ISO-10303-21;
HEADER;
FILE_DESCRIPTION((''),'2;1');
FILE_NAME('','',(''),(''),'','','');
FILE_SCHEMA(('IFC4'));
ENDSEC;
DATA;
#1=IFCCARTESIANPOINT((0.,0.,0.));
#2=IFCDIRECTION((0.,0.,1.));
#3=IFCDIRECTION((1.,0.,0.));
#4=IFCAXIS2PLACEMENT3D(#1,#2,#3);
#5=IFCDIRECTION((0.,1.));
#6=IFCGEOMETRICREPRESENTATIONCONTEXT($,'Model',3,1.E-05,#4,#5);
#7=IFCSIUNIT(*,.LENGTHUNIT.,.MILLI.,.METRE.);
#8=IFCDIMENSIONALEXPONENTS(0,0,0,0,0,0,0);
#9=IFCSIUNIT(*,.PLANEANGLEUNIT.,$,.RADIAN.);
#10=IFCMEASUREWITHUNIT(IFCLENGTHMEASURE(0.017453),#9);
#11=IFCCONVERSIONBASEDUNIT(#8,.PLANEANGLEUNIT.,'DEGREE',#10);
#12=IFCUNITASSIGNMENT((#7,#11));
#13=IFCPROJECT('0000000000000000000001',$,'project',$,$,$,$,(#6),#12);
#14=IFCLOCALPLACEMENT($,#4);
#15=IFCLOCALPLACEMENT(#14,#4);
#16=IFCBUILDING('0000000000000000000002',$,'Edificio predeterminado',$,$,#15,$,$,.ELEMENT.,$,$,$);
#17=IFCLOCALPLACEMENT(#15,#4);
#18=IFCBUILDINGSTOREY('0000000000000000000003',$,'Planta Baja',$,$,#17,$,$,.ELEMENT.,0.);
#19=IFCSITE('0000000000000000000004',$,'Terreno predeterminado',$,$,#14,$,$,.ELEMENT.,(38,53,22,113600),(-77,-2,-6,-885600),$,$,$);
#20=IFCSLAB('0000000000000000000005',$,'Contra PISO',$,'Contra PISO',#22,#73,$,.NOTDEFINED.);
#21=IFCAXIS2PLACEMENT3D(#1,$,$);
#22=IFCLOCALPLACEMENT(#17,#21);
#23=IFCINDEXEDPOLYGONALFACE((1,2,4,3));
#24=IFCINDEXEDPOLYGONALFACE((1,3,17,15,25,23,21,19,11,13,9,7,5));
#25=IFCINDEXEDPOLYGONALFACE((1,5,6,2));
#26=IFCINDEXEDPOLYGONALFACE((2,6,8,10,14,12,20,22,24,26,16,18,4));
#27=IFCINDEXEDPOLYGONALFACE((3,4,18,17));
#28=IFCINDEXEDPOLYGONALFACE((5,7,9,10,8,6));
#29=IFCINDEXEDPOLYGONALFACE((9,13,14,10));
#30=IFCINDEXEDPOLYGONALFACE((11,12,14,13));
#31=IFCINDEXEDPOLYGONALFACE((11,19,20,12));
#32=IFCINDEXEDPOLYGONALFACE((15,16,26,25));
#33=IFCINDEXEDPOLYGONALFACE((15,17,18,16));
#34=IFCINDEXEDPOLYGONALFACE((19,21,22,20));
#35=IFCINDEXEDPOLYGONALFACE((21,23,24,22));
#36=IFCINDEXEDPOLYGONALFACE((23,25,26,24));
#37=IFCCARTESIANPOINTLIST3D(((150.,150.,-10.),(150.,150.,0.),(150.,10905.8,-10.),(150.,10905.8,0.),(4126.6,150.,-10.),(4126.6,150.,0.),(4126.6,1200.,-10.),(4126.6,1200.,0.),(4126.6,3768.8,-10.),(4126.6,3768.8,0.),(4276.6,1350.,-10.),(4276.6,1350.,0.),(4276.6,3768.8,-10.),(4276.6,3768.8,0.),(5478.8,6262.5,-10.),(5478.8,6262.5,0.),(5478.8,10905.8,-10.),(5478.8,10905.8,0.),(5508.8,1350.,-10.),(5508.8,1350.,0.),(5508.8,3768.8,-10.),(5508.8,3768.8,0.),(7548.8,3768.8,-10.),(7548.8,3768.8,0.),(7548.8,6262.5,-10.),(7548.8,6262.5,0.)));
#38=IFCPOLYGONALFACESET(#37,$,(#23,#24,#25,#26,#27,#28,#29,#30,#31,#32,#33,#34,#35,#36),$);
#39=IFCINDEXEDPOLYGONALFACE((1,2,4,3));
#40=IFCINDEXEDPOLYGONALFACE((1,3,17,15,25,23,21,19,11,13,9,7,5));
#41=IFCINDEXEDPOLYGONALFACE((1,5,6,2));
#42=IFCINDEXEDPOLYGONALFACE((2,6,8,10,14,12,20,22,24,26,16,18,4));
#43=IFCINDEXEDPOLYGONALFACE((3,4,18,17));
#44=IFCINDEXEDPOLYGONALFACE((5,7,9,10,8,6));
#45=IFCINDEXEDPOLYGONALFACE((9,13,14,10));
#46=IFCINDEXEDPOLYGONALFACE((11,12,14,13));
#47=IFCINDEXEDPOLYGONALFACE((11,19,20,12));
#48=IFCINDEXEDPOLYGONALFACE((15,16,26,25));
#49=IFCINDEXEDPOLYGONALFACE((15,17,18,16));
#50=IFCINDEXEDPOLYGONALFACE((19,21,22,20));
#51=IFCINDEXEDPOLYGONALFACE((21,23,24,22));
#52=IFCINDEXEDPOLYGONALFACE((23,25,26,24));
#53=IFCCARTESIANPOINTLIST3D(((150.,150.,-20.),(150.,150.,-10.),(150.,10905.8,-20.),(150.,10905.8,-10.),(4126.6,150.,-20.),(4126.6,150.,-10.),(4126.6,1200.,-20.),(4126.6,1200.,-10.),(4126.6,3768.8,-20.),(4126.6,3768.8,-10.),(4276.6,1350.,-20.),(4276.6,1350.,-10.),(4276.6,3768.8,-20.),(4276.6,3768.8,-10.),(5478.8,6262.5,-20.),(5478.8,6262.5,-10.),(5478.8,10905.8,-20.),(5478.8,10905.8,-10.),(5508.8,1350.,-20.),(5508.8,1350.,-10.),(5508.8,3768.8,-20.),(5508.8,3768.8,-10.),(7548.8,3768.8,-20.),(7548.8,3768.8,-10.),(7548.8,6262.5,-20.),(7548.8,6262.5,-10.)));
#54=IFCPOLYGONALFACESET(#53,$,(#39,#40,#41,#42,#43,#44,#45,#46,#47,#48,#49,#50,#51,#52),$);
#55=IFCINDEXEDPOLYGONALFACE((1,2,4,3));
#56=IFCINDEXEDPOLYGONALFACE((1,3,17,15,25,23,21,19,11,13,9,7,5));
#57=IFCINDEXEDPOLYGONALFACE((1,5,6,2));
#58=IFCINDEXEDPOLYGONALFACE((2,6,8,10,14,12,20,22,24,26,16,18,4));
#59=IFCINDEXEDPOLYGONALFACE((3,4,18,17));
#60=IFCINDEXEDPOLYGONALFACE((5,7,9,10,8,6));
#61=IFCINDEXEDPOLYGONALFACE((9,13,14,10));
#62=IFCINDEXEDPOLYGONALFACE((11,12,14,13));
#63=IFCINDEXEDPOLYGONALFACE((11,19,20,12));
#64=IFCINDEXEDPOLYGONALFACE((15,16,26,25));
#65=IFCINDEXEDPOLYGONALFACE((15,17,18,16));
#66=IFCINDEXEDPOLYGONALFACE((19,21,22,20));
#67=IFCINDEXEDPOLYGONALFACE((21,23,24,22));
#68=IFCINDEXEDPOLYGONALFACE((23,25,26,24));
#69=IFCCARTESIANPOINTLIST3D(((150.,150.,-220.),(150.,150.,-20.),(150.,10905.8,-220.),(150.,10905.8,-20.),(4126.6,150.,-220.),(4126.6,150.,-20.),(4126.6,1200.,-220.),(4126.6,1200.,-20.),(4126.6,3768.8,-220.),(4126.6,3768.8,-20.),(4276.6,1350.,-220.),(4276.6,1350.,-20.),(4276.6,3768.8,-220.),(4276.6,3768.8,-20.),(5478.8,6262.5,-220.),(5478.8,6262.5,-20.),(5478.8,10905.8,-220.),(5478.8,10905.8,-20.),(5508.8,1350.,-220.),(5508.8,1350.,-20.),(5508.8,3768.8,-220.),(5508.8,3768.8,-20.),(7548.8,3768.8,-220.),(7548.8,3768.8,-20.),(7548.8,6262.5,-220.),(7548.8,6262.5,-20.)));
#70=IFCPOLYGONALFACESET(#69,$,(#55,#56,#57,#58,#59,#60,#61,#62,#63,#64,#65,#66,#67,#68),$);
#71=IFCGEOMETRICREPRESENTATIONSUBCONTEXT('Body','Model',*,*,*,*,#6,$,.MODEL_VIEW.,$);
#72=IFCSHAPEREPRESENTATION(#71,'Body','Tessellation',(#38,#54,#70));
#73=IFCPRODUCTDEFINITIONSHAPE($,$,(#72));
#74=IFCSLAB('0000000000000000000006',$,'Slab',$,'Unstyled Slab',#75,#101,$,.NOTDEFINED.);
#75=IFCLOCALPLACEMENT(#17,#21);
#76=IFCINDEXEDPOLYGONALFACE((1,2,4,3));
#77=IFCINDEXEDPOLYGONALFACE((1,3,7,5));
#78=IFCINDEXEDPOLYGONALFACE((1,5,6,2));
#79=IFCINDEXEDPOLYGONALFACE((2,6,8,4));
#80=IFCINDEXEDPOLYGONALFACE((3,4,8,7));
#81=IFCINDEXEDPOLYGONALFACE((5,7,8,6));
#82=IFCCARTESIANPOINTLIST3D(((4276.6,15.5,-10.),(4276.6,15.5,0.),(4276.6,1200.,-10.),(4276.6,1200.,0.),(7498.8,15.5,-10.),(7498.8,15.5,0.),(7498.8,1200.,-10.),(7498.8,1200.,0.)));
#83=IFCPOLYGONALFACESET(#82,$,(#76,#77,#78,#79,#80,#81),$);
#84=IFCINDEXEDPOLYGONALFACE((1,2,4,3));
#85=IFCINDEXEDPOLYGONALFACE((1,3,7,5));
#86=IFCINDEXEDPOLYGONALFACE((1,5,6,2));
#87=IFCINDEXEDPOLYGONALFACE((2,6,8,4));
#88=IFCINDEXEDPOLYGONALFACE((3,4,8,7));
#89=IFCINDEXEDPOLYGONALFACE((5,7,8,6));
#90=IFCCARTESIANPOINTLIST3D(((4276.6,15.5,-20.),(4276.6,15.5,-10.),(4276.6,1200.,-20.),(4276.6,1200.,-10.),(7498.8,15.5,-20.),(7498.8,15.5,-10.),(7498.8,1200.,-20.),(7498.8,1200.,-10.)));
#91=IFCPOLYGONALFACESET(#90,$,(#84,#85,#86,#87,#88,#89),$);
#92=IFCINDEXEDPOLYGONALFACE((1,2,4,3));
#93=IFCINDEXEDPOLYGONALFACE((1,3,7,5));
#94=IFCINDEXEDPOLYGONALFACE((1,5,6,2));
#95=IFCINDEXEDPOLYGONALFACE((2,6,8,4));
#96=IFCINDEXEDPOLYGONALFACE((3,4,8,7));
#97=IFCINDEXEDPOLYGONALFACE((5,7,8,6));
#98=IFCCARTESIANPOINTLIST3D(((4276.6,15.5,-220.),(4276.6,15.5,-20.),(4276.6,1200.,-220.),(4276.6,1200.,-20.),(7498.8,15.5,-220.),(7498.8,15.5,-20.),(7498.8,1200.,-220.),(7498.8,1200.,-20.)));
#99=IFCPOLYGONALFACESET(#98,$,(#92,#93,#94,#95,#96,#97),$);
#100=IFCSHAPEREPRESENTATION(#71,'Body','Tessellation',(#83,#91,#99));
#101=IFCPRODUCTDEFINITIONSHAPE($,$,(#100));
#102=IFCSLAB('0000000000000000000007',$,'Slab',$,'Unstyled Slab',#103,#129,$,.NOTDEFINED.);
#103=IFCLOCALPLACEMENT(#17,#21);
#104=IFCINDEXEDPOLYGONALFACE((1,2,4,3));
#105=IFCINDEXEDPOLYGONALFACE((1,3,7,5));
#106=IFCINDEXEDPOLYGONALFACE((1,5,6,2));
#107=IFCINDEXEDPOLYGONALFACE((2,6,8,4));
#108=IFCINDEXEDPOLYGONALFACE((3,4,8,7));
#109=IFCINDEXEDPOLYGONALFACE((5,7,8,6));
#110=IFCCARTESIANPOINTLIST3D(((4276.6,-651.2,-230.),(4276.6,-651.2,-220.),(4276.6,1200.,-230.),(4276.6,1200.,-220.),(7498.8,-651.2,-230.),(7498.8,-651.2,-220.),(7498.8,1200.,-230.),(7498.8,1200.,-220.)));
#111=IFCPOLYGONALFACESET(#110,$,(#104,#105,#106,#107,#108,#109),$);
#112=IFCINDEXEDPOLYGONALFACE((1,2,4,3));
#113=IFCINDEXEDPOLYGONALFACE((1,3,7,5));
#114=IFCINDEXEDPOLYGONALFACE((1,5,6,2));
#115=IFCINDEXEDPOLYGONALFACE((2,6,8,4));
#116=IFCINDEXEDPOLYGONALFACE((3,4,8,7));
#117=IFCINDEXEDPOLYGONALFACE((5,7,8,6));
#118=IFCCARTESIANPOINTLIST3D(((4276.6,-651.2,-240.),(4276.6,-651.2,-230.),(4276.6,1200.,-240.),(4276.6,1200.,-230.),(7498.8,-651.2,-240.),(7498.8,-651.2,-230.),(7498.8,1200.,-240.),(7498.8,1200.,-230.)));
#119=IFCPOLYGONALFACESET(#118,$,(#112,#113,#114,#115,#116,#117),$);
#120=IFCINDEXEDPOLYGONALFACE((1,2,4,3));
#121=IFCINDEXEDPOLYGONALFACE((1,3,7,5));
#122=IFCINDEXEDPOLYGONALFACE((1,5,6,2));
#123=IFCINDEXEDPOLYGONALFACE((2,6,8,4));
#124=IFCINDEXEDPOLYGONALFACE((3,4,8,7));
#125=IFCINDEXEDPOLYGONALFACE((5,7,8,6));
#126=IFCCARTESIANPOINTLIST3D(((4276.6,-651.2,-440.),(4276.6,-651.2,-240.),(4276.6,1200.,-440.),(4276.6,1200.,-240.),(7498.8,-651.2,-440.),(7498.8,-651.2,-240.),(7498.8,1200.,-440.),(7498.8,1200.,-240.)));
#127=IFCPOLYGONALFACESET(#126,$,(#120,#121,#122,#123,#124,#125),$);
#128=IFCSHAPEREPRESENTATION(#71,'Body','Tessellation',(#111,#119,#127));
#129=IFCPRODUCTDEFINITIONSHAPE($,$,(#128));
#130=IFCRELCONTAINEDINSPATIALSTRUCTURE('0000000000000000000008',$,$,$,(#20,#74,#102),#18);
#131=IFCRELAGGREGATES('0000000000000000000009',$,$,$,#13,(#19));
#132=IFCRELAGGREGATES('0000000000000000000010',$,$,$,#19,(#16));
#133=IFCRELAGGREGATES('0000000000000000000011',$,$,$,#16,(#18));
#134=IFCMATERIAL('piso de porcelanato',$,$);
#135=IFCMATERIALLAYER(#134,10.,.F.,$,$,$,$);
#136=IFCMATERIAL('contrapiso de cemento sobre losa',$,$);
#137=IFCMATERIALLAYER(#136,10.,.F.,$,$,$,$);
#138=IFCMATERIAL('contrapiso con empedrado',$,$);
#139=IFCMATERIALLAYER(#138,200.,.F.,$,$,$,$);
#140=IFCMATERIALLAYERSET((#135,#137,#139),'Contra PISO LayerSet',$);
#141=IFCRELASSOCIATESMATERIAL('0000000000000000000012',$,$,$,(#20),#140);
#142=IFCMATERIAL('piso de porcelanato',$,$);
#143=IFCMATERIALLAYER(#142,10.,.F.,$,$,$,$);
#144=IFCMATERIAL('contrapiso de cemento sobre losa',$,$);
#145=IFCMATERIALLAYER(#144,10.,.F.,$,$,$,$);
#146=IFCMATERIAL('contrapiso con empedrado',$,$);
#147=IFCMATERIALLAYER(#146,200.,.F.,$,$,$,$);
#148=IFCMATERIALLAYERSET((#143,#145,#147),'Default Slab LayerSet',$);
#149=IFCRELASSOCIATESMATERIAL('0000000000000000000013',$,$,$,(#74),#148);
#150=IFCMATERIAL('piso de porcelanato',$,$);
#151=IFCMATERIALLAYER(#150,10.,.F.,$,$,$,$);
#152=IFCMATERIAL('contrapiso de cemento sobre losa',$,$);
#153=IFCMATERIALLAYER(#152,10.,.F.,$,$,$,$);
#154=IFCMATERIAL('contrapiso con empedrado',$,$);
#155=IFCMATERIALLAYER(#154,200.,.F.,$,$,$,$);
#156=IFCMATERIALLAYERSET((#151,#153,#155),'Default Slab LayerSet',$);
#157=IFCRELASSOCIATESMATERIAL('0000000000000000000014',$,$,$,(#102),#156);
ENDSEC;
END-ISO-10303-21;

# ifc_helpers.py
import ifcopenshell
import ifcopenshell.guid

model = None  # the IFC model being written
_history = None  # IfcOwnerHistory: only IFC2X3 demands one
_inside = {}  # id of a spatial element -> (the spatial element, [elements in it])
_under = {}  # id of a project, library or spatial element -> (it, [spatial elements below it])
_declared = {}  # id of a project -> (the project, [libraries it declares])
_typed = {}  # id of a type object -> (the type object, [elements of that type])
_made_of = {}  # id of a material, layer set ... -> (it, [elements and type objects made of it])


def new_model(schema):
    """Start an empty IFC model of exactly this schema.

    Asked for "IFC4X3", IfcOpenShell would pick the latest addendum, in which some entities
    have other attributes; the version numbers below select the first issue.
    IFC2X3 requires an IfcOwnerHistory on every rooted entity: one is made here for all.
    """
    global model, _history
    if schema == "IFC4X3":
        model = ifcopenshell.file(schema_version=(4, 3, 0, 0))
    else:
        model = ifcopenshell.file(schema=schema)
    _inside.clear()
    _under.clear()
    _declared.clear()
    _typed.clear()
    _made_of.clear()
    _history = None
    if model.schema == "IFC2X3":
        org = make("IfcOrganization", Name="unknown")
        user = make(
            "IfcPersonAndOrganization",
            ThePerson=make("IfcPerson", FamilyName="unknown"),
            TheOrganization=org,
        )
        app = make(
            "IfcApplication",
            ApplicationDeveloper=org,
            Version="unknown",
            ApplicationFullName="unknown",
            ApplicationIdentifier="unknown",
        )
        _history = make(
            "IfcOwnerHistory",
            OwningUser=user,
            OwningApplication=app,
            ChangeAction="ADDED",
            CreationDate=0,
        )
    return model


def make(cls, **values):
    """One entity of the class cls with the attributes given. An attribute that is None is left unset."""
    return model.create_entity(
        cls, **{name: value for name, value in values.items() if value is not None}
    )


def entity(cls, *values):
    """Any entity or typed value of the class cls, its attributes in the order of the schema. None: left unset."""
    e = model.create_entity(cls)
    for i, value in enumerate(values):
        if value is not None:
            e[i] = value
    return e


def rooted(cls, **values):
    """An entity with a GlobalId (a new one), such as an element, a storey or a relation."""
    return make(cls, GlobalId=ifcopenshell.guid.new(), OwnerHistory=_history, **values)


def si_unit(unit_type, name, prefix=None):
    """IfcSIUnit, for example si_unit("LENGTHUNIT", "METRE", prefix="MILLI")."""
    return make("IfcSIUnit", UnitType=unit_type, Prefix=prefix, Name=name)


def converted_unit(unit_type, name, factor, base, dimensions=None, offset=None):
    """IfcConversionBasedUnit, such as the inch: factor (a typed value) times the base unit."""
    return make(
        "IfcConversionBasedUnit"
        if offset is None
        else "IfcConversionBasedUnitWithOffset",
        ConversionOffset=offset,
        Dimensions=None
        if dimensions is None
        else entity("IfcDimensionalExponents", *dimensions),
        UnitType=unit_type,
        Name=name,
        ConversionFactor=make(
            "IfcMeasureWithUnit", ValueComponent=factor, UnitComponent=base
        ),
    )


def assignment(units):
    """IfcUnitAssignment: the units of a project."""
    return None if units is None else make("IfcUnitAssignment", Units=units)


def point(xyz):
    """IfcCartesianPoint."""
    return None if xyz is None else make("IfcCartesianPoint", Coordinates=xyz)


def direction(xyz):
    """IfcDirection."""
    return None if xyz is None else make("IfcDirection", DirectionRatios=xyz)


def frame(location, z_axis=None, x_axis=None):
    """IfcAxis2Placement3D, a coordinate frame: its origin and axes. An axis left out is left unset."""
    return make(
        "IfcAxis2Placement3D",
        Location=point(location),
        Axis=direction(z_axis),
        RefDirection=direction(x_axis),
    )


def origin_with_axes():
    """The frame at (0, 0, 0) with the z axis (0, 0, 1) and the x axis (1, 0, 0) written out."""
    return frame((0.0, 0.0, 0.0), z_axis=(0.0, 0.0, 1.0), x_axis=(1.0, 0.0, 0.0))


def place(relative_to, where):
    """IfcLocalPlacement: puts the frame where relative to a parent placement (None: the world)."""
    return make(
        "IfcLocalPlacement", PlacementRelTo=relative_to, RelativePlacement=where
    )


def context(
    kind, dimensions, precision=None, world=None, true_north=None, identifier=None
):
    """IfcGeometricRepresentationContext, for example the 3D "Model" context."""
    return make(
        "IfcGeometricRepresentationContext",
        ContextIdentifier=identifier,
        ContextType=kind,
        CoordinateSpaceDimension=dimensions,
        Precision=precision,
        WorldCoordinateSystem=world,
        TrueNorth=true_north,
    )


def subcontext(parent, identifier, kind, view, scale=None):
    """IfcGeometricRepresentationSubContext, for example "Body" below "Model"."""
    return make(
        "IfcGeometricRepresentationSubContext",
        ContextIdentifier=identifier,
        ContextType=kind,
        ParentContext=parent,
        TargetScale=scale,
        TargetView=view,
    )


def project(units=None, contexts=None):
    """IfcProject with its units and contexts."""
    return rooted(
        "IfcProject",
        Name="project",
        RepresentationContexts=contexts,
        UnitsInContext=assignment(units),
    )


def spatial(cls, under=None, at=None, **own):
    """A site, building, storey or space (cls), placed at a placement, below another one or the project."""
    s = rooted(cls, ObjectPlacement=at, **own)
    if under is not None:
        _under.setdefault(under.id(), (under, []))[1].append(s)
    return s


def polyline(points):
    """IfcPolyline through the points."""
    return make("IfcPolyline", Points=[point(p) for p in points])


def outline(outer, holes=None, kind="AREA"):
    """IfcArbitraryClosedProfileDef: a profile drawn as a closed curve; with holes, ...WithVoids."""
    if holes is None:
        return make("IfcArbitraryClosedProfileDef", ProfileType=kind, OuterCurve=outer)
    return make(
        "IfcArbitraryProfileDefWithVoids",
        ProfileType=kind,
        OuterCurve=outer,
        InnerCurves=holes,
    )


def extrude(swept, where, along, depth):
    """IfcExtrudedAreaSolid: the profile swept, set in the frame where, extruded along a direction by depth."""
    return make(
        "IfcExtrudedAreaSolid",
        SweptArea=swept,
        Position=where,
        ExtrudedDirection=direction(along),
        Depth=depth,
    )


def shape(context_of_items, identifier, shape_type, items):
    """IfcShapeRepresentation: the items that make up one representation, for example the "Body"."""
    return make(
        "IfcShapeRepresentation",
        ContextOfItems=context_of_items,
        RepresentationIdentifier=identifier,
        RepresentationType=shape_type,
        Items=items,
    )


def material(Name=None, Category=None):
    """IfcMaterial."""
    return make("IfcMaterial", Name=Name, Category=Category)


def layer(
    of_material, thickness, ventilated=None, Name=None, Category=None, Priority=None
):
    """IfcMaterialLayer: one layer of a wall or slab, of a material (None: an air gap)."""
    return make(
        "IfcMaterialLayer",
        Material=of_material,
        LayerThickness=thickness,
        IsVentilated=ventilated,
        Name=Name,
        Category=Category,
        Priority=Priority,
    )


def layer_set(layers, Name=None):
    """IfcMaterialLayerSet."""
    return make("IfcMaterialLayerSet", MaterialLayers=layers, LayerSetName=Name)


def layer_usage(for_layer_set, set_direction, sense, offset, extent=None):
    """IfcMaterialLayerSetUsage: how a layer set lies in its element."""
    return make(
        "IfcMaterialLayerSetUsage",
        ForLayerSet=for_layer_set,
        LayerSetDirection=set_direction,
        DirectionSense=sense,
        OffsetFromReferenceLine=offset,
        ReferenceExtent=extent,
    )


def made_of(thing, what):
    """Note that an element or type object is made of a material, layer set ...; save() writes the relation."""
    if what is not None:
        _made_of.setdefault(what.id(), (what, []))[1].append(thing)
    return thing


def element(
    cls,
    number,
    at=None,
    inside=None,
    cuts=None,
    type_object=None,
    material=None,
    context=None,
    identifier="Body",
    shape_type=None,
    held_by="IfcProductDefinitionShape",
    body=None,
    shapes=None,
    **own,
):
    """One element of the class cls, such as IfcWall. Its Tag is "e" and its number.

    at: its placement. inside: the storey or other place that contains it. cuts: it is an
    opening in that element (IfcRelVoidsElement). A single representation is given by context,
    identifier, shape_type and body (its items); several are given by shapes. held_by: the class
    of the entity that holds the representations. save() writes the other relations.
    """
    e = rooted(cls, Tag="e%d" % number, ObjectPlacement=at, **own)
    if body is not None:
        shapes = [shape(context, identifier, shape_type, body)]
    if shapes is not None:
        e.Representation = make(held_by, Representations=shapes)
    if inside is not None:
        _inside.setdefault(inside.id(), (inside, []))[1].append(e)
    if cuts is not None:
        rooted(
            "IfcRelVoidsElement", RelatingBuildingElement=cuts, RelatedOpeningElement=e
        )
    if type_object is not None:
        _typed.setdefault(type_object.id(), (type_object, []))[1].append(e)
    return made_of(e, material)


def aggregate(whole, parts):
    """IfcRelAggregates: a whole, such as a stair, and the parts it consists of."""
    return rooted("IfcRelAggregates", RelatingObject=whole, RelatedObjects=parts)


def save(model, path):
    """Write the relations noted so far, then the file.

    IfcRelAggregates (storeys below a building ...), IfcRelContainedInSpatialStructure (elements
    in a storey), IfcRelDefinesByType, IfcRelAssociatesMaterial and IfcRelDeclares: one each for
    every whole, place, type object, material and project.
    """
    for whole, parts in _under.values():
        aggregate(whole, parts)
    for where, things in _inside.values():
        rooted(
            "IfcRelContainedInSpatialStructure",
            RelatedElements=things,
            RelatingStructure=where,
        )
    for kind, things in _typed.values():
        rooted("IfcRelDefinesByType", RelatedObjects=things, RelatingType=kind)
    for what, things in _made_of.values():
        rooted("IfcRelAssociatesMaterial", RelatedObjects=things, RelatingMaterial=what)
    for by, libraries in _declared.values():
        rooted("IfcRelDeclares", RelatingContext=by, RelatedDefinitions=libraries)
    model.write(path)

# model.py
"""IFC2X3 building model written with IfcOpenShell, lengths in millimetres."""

from ifc_helpers import new_model, entity, si_unit, converted_unit, direction, frame, origin_with_axes, place, context, subcontext, project, spatial, polyline, outline, extrude, material, layer, layer_set, layer_usage, element, save


model = new_model("IFC2X3")

# Units and contexts
model_context = context("Model", 3, precision=1e-05, world=origin_with_axes(), true_north=direction((0.0, 1.0)))
body_context = subcontext(model_context, "Body", "Model", "MODEL_VIEW")
ifc_project = project(units=[si_unit("LENGTHUNIT", "METRE", prefix="MILLI"), converted_unit("PLANEANGLEUNIT", "DEGREE", entity("IfcLengthMeasure", 0.017453), si_unit("PLANEANGLEUNIT", "RADIAN"), dimensions=[0, 0, 0, 0, 0, 0, 0])], contexts=[model_context])

# Site, building, storey
site_placement = place(None, origin_with_axes())
site = spatial("IfcSite", under=ifc_project, at=site_placement, Name="Terreno predeterminado", CompositionType="ELEMENT", RefLatitude=(38, 53, 22, 113600), RefLongitude=(-77, -2, -6, -885600))
building_placement = place(site_placement, origin_with_axes())
building = spatial("IfcBuilding", under=site, at=building_placement, Name="Edificio predeterminado", CompositionType="ELEMENT")
storey_placement = place(building_placement, origin_with_axes())
storey = spatial("IfcBuildingStorey", under=building, at=storey_placement, Name="Planta Baja", CompositionType="ELEMENT", Elevation=0.0)

# Slabs
ifc_material_1 = material(Name="piso de porcelanato")
ifc_layer_1 = layer(ifc_material_1, 10.0, ventilated=False)
ifc_material_2 = material(Name="contrapiso de cemento sobre losa")
ifc_layer_2 = layer(ifc_material_2, 10.0, ventilated=False)
ifc_material_3 = material(Name="contrapiso con empedrado")
ifc_layer_3 = layer(ifc_material_3, 200.0, ventilated=False)
ifc_layer_set_1 = layer_set([ifc_layer_1, ifc_layer_2, ifc_layer_3], Name="Contra PISO LayerSet")
ifc_layer_usage_1 = layer_usage(ifc_layer_set_1, "AXIS3", "POSITIVE", 0.0)
slab_1_placement = place(storey_placement, origin_with_axes())
element("IfcSlab", 1, at=slab_1_placement, inside=storey, material=ifc_layer_usage_1, Name="Contra PISO", ObjectType="Contra PISO", PredefinedType="NOTDEFINED", context=body_context, shape_type="SweptSolid", body=[
    extrude(outline(polyline([(0.0, -2493.7), (2070.0, -2493.7), (2070.0, -7137.0), (7398.8, -7137.0), (7398.8, 3618.8), (3422.2, 3618.8), (3422.2, 2568.8), (3422.2, 0.0), (3272.2, 0.0), (3272.2, 2418.8), (2040.0, 2418.8), (2040.0, 0.0), (0.0, 0.0), (0.0, -2493.7)])), frame((7548.8, 3768.8, -10.0), z_axis=(0.0, 0.0, 1.0), x_axis=(-1.0, 0.0, 0.0)), (0.0, 0.0, 1.0), 10.0),
    extrude(outline(polyline([(0.0, -2493.7), (2070.0, -2493.7), (2070.0, -7137.0), (7398.8, -7137.0), (7398.8, 3618.8), (3422.2, 3618.8), (3422.2, 2568.8), (3422.2, 0.0), (3272.2, 0.0), (3272.2, 2418.8), (2040.0, 2418.8), (2040.0, 0.0), (0.0, 0.0), (0.0, -2493.7)])), frame((7548.8, 3768.8, -20.0), z_axis=(0.0, 0.0, 1.0), x_axis=(-1.0, 0.0, 0.0)), (0.0, 0.0, 1.0), 10.0),
    extrude(outline(polyline([(0.0, -2493.7), (2070.0, -2493.7), (2070.0, -7137.0), (7398.8, -7137.0), (7398.8, 3618.8), (3422.2, 3618.8), (3422.2, 2568.8), (3422.2, 0.0), (3272.2, 0.0), (3272.2, 2418.8), (2040.0, 2418.8), (2040.0, 0.0), (0.0, 0.0), (0.0, -2493.7)])), frame((7548.8, 3768.8, -220.0), z_axis=(0.0, 0.0, 1.0), x_axis=(-1.0, 0.0, 0.0)), (0.0, 0.0, 1.0), 200.0),
])
ifc_material_4 = material(Name="piso de porcelanato")
ifc_layer_4 = layer(ifc_material_4, 10.0, ventilated=False)
ifc_material_5 = material(Name="contrapiso de cemento sobre losa")
ifc_layer_5 = layer(ifc_material_5, 10.0, ventilated=False)
ifc_material_6 = material(Name="contrapiso con empedrado")
ifc_layer_6 = layer(ifc_material_6, 200.0, ventilated=False)
ifc_layer_set_2 = layer_set([ifc_layer_4, ifc_layer_5, ifc_layer_6], Name="Default Slab LayerSet")
ifc_layer_usage_2 = layer_usage(ifc_layer_set_2, "AXIS3", "POSITIVE", 0.0)
slab_2_placement = place(storey_placement, origin_with_axes())
element("IfcSlab", 2, at=slab_2_placement, inside=storey, material=ifc_layer_usage_2, Name="Slab", ObjectType="Unstyled Slab", PredefinedType="NOTDEFINED", context=body_context, shape_type="SweptSolid", body=[
    extrude(outline(polyline([(0.0, 0.0), (3222.2, 0.0), (3222.2, 1184.5), (0.0, 1184.5), (0.0, 0.0)])), frame((4276.6, 1200.0, -10.0), z_axis=(0.0, 0.0, -1.0), x_axis=(1.0, 0.0, 0.0)), (0.0, 0.0, -1.0), 10.0),
    extrude(outline(polyline([(0.0, 0.0), (3222.2, 0.0), (3222.2, 1184.5), (0.0, 1184.5), (0.0, 0.0)])), frame((4276.6, 1200.0, -20.0), z_axis=(0.0, 0.0, -1.0), x_axis=(1.0, 0.0, 0.0)), (0.0, 0.0, -1.0), 10.0),
    extrude(outline(polyline([(0.0, 0.0), (3222.2, 0.0), (3222.2, 1184.5), (0.0, 1184.5), (0.0, 0.0)])), frame((4276.6, 1200.0, -220.0), z_axis=(0.0, 0.0, -1.0), x_axis=(1.0, 0.0, 0.0)), (0.0, 0.0, -1.0), 200.0),
])
ifc_material_7 = material(Name="piso de porcelanato")
ifc_layer_7 = layer(ifc_material_7, 10.0, ventilated=False)
ifc_material_8 = material(Name="contrapiso de cemento sobre losa")
ifc_layer_8 = layer(ifc_material_8, 10.0, ventilated=False)
ifc_material_9 = material(Name="contrapiso con empedrado")
ifc_layer_9 = layer(ifc_material_9, 200.0, ventilated=False)
ifc_layer_set_3 = layer_set([ifc_layer_7, ifc_layer_8, ifc_layer_9], Name="Default Slab LayerSet")
ifc_layer_usage_3 = layer_usage(ifc_layer_set_3, "AXIS3", "POSITIVE", 0.0)
slab_3_placement = place(storey_placement, origin_with_axes())
element("IfcSlab", 3, at=slab_3_placement, inside=storey, material=ifc_layer_usage_3, Name="Slab", ObjectType="Unstyled Slab", PredefinedType="NOTDEFINED", context=body_context, shape_type="SweptSolid", body=[
    extrude(outline(polyline([(0.0, 0.0), (3222.2, 0.0), (3222.2, 1851.2), (0.0, 1851.2), (0.0, 0.0)])), frame((4276.6, 1200.0, -230.0), z_axis=(0.0, 0.0, -1.0), x_axis=(1.0, 0.0, 0.0)), (0.0, 0.0, -1.0), 10.0),
    extrude(outline(polyline([(0.0, 0.0), (3222.2, 0.0), (3222.2, 1851.2), (0.0, 1851.2), (0.0, 0.0)])), frame((4276.6, 1200.0, -240.0), z_axis=(0.0, 0.0, -1.0), x_axis=(1.0, 0.0, 0.0)), (0.0, 0.0, -1.0), 10.0),
    extrude(outline(polyline([(0.0, 0.0), (3222.2, 0.0), (3222.2, 1851.2), (0.0, 1851.2), (0.0, 0.0)])), frame((4276.6, 1200.0, -440.0), z_axis=(0.0, 0.0, -1.0), x_axis=(1.0, 0.0, 0.0)), (0.0, 0.0, -1.0), 200.0),
])

save(model, "model.ifc")
